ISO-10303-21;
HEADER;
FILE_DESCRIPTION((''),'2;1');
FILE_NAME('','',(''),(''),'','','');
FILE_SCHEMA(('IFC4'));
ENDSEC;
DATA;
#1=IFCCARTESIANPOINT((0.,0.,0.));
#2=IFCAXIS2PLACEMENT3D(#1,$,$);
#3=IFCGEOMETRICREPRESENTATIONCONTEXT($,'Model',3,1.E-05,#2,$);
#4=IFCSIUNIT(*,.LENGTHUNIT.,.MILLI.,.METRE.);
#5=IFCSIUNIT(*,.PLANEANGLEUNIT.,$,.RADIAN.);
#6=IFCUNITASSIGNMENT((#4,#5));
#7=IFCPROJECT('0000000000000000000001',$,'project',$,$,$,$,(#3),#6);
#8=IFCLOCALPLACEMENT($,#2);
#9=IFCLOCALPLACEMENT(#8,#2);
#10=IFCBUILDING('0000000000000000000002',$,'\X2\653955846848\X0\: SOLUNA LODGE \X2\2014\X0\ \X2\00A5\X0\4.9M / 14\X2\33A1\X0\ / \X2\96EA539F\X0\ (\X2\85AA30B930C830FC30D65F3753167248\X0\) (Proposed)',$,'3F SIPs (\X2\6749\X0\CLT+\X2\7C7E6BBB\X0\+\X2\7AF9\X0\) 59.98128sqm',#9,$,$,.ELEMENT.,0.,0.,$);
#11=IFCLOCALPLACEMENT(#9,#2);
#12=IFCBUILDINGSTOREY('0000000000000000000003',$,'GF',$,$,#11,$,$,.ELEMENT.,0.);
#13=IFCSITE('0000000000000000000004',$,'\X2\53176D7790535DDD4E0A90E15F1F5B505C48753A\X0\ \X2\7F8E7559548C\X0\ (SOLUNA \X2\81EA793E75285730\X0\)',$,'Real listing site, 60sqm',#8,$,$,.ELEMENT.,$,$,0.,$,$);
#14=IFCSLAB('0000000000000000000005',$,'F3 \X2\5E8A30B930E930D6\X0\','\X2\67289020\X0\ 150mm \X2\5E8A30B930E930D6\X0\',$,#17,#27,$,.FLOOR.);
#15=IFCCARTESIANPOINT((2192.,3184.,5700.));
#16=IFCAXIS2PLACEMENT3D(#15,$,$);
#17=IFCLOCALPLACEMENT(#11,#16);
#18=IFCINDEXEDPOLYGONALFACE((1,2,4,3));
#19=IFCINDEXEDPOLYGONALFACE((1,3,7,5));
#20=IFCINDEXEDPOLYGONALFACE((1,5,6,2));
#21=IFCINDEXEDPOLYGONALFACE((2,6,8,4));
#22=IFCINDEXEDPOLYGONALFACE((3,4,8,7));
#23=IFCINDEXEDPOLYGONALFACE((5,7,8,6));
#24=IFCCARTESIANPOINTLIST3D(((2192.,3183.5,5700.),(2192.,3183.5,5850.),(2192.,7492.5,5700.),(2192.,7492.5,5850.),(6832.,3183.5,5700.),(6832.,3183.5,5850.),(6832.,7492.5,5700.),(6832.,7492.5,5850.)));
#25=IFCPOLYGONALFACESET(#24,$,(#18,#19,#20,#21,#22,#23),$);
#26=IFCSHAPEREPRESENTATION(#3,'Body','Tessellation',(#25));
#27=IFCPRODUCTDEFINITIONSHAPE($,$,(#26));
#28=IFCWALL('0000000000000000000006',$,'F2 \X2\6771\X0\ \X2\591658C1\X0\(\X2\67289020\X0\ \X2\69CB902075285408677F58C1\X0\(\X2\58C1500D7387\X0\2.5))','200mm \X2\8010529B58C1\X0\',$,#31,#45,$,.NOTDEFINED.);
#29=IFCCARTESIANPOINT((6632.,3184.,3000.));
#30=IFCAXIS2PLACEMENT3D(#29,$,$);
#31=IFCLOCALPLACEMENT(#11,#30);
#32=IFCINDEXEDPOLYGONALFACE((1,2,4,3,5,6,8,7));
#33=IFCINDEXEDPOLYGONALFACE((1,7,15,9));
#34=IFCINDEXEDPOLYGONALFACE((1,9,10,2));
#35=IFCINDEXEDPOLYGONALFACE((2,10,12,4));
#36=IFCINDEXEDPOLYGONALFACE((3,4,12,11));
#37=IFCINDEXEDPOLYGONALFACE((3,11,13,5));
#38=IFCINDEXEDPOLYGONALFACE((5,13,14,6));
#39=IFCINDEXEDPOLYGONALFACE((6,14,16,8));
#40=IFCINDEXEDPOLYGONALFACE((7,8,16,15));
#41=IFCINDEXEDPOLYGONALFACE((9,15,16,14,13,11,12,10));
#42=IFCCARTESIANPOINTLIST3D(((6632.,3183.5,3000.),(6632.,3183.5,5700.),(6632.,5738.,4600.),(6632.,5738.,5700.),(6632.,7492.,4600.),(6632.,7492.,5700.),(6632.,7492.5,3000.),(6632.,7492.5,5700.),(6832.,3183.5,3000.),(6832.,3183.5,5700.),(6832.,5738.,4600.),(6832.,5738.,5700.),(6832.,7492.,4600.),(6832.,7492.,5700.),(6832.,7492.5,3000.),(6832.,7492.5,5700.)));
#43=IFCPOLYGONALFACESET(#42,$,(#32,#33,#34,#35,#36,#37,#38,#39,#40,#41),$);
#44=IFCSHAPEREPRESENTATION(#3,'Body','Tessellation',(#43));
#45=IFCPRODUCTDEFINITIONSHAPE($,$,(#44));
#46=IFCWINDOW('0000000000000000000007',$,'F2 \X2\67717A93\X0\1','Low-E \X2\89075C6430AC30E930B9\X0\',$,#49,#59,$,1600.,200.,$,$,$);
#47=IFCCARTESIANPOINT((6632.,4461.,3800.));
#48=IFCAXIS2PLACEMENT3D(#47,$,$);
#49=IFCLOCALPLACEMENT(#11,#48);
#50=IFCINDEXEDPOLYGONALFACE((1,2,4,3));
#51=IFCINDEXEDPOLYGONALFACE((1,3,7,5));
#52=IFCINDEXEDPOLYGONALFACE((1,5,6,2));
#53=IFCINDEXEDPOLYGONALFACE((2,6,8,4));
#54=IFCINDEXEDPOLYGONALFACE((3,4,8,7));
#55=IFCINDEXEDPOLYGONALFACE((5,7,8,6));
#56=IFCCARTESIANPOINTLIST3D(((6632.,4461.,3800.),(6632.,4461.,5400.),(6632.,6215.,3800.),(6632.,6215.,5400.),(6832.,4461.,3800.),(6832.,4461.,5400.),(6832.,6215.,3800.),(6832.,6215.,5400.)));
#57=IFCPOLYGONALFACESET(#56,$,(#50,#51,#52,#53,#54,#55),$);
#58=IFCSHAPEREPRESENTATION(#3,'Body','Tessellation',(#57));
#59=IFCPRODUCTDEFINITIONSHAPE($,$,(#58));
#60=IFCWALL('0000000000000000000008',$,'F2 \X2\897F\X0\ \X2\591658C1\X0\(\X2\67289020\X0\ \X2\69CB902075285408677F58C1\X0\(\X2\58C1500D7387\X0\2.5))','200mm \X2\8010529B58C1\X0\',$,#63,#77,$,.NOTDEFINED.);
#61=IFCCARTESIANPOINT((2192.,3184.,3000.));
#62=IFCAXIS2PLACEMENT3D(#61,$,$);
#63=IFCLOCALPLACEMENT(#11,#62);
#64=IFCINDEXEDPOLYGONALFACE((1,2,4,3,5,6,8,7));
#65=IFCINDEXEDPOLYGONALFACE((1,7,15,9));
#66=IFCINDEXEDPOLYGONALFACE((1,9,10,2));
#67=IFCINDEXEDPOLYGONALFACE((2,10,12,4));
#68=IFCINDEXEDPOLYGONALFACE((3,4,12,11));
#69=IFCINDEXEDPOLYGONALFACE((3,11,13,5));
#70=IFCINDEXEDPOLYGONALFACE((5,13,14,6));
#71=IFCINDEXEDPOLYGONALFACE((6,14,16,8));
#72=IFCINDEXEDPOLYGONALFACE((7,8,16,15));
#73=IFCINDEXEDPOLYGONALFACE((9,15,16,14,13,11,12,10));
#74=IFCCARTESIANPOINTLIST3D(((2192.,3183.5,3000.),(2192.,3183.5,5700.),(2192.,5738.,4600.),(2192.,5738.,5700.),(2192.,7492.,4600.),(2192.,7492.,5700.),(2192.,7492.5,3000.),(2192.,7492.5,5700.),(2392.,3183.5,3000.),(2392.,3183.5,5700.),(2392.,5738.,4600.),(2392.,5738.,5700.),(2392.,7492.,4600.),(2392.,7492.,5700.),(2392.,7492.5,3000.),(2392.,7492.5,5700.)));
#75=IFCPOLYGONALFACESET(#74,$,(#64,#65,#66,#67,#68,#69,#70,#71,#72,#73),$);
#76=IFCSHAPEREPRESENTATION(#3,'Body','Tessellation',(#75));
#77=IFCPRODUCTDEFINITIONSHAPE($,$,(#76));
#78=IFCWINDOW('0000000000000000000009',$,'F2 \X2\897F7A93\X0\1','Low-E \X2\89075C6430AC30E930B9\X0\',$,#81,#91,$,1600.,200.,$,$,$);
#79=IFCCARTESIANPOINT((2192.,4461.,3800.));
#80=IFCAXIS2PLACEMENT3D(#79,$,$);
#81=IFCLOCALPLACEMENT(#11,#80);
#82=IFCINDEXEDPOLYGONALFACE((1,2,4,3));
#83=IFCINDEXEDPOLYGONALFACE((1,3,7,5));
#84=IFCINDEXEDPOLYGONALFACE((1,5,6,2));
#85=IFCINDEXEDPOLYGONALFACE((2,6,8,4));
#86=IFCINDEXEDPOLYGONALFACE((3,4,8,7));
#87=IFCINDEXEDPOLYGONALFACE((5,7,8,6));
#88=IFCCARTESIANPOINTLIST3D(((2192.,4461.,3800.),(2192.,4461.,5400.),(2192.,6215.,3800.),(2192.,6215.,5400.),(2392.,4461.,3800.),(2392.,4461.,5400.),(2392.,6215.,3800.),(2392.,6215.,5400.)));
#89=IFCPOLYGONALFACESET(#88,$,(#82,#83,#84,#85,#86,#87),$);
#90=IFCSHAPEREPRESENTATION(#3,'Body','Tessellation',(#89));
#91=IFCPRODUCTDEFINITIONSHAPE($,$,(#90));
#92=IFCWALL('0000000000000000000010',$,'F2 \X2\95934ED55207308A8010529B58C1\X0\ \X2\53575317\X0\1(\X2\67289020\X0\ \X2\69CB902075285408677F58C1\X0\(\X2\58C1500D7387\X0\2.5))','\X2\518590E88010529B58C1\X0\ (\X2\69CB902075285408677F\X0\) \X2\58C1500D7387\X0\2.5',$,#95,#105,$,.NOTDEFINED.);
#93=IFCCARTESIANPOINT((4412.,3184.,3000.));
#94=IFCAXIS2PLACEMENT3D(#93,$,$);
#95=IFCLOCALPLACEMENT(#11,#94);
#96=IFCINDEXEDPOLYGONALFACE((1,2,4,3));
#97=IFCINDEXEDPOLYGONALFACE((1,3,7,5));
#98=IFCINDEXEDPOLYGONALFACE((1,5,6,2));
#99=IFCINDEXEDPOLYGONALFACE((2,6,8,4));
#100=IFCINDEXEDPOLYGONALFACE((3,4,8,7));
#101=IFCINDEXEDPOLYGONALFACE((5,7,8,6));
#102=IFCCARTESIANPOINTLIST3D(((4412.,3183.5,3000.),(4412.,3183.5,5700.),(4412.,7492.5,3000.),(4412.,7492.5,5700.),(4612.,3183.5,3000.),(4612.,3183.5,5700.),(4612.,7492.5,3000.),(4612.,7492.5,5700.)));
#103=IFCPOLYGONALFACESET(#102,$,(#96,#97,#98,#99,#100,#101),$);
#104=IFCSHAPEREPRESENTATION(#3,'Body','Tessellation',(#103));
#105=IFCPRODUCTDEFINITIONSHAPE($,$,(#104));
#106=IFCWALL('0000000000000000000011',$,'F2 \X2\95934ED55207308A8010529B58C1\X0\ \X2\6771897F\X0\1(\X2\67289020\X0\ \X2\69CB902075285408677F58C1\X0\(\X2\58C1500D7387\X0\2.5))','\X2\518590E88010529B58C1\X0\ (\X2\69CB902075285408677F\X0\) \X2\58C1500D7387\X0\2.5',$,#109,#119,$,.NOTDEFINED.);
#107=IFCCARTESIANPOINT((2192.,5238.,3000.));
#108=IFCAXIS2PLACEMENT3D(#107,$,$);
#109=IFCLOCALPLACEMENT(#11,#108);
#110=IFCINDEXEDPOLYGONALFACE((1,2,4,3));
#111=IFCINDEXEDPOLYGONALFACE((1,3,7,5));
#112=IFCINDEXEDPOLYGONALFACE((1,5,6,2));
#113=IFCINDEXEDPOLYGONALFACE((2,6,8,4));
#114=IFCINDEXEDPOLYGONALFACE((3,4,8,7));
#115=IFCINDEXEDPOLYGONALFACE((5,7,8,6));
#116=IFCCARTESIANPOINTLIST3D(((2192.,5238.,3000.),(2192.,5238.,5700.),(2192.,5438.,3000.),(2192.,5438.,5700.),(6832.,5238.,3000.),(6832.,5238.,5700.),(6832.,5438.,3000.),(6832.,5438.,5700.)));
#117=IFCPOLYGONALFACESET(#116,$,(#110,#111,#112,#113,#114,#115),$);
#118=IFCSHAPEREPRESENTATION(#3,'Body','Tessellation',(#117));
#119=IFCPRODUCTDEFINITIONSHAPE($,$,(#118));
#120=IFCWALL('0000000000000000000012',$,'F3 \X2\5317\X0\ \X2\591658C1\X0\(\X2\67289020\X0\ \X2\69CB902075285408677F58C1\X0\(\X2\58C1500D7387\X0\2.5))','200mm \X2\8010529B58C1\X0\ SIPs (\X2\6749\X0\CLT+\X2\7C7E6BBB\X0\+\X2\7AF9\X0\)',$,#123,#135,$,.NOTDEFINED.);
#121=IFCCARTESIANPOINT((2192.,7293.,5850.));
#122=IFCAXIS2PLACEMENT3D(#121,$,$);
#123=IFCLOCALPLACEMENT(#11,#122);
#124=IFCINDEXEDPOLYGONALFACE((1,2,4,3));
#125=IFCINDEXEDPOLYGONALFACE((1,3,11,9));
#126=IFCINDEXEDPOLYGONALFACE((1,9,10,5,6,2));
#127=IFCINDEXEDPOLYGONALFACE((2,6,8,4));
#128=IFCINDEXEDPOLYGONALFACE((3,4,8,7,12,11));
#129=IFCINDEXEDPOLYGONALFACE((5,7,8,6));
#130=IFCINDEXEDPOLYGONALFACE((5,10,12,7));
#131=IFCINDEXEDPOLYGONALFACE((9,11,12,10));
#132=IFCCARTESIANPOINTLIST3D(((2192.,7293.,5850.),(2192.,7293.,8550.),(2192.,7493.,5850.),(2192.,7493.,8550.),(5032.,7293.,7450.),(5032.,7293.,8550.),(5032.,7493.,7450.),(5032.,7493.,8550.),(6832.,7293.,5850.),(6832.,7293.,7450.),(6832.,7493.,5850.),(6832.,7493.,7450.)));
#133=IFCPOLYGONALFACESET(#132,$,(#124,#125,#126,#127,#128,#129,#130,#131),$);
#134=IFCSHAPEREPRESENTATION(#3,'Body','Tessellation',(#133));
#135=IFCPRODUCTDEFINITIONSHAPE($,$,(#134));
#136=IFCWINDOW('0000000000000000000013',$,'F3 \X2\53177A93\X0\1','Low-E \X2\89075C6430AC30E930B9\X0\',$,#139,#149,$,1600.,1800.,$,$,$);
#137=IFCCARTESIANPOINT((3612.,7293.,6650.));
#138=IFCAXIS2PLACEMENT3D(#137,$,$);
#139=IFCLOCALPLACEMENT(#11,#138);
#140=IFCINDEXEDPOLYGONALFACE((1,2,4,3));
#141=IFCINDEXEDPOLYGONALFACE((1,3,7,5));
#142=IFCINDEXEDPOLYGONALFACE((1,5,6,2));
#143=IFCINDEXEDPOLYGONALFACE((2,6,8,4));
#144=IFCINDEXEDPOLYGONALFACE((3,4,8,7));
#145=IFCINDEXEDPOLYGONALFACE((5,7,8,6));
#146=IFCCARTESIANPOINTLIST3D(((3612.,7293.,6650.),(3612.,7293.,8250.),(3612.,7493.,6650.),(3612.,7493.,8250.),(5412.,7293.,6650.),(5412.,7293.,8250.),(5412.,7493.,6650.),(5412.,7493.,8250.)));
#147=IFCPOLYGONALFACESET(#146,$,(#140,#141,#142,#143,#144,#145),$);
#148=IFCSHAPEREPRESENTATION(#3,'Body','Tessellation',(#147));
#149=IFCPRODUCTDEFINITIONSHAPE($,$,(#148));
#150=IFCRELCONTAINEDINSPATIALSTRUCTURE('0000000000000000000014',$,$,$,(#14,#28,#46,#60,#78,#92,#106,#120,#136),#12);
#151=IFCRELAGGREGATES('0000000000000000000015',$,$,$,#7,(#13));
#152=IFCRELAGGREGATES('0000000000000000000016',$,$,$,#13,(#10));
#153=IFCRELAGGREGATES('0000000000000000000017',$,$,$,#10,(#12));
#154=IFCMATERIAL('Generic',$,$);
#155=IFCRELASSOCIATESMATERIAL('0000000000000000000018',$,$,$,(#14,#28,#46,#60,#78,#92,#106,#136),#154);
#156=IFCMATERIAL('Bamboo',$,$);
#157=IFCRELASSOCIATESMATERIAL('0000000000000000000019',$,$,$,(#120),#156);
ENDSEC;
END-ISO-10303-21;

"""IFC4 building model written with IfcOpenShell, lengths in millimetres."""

from ifc_helpers import new_model, si_unit, frame, frame_2d, origin, place, context, project, spatial, rectangle, extrude, material, element, fill, save


model = new_model("IFC4")

# Units and contexts
model_context = context("Model", 3, precision=1e-05, world=origin())
ifc_project = project(units=[si_unit("LENGTHUNIT", "METRE", prefix="MILLI"), si_unit("PLANEANGLEUNIT", "RADIAN")], contexts=[model_context])

# Site, building, storey
site_placement = place(None, origin())
site = spatial("IfcSite", under=ifc_project, at=site_placement, Name="北海道川上郡弟子屈町 美留和 (SOLUNA 自社用地)", ObjectType="Real listing site, 60sqm", CompositionType="ELEMENT", RefElevation=0.0)
building_placement = place(site_placement, origin())
building = spatial("IfcBuilding", under=site, at=building_placement, Name="改善案: SOLUNA LODGE — ¥4.9M / 14㎡ / 雪原 (薪ストーブ強化版) (Proposed)", ObjectType="3F SIPs (杉CLT+籾殻+竹) 59.98128sqm", CompositionType="ELEMENT", ElevationOfRefHeight=0.0, ElevationOfTerrain=0.0)
storey_placement = place(building_placement, origin())
storey = spatial("IfcBuildingStorey", under=building, at=storey_placement, Name="GF", CompositionType="ELEMENT", Elevation=0.0)

# Slab
ifc_material_1 = material(Name="Generic")
slab_placement = place(storey_placement, frame((2192.0, 3184.0, 5700.0)))
element("IfcSlab", 1, at=slab_placement, inside=storey, material=ifc_material_1, Name="F3 床スラブ", Description="木造 150mm 床スラブ", PredefinedType="FLOOR", context=model_context, shape_type="SweptSolid", body=[
    extrude(rectangle(XDim=4640.0, YDim=4309.0, at=frame_2d((2320.0, 2154.0))), frame((2192.0, 3184.0, 5700.0)), (0.0, 0.0, 1.0), 150.0),
])

# Walls, openings, windows
wall_1_placement = place(storey_placement, frame((6632.0, 3184.0, 3000.0)))
wall_1 = element("IfcWall", 2, at=wall_1_placement, inside=storey, material=ifc_material_1, Name="F2 東 外壁(木造 構造用合板壁(壁倍率2.5))", Description="200mm 耐力壁", PredefinedType="NOTDEFINED", context=model_context, shape_type="SweptSolid", body=[
    extrude(rectangle(XDim=200.0, YDim=4309.0, at=frame_2d((100.0, 2154.0))), frame((6632.0, 3184.0, 3000.0)), (0.0, 0.0, 1.0), 2700.0),
])
opening_1_placement = place(storey_placement, frame((6632.0, 4461.0, 3800.0)))
opening_1 = element("IfcOpeningElement", 3, at=opening_1_placement, cuts=wall_1, PredefinedType="NOTDEFINED", context=model_context, shape_type="SweptSolid", body=[
    extrude(rectangle(XDim=200.0, YDim=1754.0, at=frame_2d((100.0, 877.0))), frame((6632.0, 4461.0, 3800.0)), (0.0, 0.0, 1.0), 1600.0),
])
window_1_placement = place(storey_placement, frame((6632.0, 4461.0, 3800.0)))
window_1 = element("IfcWindow", 4, at=window_1_placement, inside=storey, material=ifc_material_1, Name="F2 東窓1", Description="Low-E 複層ガラス", OverallHeight=1600.0, OverallWidth=200.0, context=model_context, shape_type="SweptSolid", body=[
    extrude(rectangle(XDim=200.0, YDim=1754.0, at=frame_2d((100.0, 877.0))), frame((6632.0, 4461.0, 3800.0)), (0.0, 0.0, 1.0), 1600.0),
])
fill(opening_1, window_1)
wall_2_placement = place(storey_placement, frame((2192.0, 3184.0, 3000.0)))
wall_2 = element("IfcWall", 5, at=wall_2_placement, inside=storey, material=ifc_material_1, Name="F2 西 外壁(木造 構造用合板壁(壁倍率2.5))", Description="200mm 耐力壁", PredefinedType="NOTDEFINED", context=model_context, shape_type="SweptSolid", body=[
    extrude(rectangle(XDim=200.0, YDim=4309.0, at=frame_2d((100.0, 2154.0))), frame((2192.0, 3184.0, 3000.0)), (0.0, 0.0, 1.0), 2700.0),
])
opening_2_placement = place(storey_placement, frame((2192.0, 4461.0, 3800.0)))
opening_2 = element("IfcOpeningElement", 6, at=opening_2_placement, cuts=wall_2, PredefinedType="NOTDEFINED", context=model_context, shape_type="SweptSolid", body=[
    extrude(rectangle(XDim=200.0, YDim=1754.0, at=frame_2d((100.0, 877.0))), frame((2192.0, 4461.0, 3800.0)), (0.0, 0.0, 1.0), 1600.0),
])
window_2_placement = place(storey_placement, frame((2192.0, 4461.0, 3800.0)))
window_2 = element("IfcWindow", 7, at=window_2_placement, inside=storey, material=ifc_material_1, Name="F2 西窓1", Description="Low-E 複層ガラス", OverallHeight=1600.0, OverallWidth=200.0, context=model_context, shape_type="SweptSolid", body=[
    extrude(rectangle(XDim=200.0, YDim=1754.0, at=frame_2d((100.0, 877.0))), frame((2192.0, 4461.0, 3800.0)), (0.0, 0.0, 1.0), 1600.0),
])
fill(opening_2, window_2)

# Walls
wall_3_placement = place(storey_placement, frame((4412.0, 3184.0, 3000.0)))
element("IfcWall", 8, at=wall_3_placement, inside=storey, material=ifc_material_1, Name="F2 間仕切り耐力壁 南北1(木造 構造用合板壁(壁倍率2.5))", Description="内部耐力壁 (構造用合板) 壁倍率2.5", PredefinedType="NOTDEFINED", context=model_context, shape_type="SweptSolid", body=[
    extrude(rectangle(XDim=200.0, YDim=4309.0, at=frame_2d((100.0, 2154.0))), frame((4412.0, 3184.0, 3000.0)), (0.0, 0.0, 1.0), 2700.0),
])
wall_4_placement = place(storey_placement, frame((2192.0, 5238.0, 3000.0)))
element("IfcWall", 9, at=wall_4_placement, inside=storey, material=ifc_material_1, Name="F2 間仕切り耐力壁 東西1(木造 構造用合板壁(壁倍率2.5))", Description="内部耐力壁 (構造用合板) 壁倍率2.5", PredefinedType="NOTDEFINED", context=model_context, shape_type="SweptSolid", body=[
    extrude(rectangle(XDim=4640.0, YDim=200.0, at=frame_2d((2320.0, 100.0))), frame((2192.0, 5238.0, 3000.0)), (0.0, 0.0, 1.0), 2700.0),
])

# Wall, opening, window
ifc_material_2 = material(Name="Bamboo")
wall_5_placement = place(storey_placement, frame((2192.0, 7293.0, 5850.0)))
wall_5 = element("IfcWall", 10, at=wall_5_placement, inside=storey, material=ifc_material_2, Name="F3 北 外壁(木造 構造用合板壁(壁倍率2.5))", Description="200mm 耐力壁 SIPs (杉CLT+籾殻+竹)", PredefinedType="NOTDEFINED", context=model_context, shape_type="SweptSolid", body=[
    extrude(rectangle(XDim=4640.0, YDim=200.0, at=frame_2d((2320.0, 100.0))), frame((2192.0, 7293.0, 5850.0)), (0.0, 0.0, 1.0), 2700.0),
])
opening_3_placement = place(storey_placement, frame((3612.0, 7293.0, 6650.0)))
opening_3 = element("IfcOpeningElement", 11, at=opening_3_placement, cuts=wall_5, PredefinedType="NOTDEFINED", context=model_context, shape_type="SweptSolid", body=[
    extrude(rectangle(XDim=1800.0, YDim=200.0, at=frame_2d((900.0, 100.0))), frame((3612.0, 7293.0, 6650.0)), (0.0, 0.0, 1.0), 1600.0),
])
window_3_placement = place(storey_placement, frame((3612.0, 7293.0, 6650.0)))
window_3 = element("IfcWindow", 12, at=window_3_placement, inside=storey, material=ifc_material_1, Name="F3 北窓1", Description="Low-E 複層ガラス", OverallHeight=1600.0, OverallWidth=1800.0, context=model_context, shape_type="SweptSolid", body=[
    extrude(rectangle(XDim=1800.0, YDim=200.0, at=frame_2d((900.0, 100.0))), frame((3612.0, 7293.0, 6650.0)), (0.0, 0.0, 1.0), 1600.0),
])
fill(opening_3, window_3)

save(model, "model.ifc")
